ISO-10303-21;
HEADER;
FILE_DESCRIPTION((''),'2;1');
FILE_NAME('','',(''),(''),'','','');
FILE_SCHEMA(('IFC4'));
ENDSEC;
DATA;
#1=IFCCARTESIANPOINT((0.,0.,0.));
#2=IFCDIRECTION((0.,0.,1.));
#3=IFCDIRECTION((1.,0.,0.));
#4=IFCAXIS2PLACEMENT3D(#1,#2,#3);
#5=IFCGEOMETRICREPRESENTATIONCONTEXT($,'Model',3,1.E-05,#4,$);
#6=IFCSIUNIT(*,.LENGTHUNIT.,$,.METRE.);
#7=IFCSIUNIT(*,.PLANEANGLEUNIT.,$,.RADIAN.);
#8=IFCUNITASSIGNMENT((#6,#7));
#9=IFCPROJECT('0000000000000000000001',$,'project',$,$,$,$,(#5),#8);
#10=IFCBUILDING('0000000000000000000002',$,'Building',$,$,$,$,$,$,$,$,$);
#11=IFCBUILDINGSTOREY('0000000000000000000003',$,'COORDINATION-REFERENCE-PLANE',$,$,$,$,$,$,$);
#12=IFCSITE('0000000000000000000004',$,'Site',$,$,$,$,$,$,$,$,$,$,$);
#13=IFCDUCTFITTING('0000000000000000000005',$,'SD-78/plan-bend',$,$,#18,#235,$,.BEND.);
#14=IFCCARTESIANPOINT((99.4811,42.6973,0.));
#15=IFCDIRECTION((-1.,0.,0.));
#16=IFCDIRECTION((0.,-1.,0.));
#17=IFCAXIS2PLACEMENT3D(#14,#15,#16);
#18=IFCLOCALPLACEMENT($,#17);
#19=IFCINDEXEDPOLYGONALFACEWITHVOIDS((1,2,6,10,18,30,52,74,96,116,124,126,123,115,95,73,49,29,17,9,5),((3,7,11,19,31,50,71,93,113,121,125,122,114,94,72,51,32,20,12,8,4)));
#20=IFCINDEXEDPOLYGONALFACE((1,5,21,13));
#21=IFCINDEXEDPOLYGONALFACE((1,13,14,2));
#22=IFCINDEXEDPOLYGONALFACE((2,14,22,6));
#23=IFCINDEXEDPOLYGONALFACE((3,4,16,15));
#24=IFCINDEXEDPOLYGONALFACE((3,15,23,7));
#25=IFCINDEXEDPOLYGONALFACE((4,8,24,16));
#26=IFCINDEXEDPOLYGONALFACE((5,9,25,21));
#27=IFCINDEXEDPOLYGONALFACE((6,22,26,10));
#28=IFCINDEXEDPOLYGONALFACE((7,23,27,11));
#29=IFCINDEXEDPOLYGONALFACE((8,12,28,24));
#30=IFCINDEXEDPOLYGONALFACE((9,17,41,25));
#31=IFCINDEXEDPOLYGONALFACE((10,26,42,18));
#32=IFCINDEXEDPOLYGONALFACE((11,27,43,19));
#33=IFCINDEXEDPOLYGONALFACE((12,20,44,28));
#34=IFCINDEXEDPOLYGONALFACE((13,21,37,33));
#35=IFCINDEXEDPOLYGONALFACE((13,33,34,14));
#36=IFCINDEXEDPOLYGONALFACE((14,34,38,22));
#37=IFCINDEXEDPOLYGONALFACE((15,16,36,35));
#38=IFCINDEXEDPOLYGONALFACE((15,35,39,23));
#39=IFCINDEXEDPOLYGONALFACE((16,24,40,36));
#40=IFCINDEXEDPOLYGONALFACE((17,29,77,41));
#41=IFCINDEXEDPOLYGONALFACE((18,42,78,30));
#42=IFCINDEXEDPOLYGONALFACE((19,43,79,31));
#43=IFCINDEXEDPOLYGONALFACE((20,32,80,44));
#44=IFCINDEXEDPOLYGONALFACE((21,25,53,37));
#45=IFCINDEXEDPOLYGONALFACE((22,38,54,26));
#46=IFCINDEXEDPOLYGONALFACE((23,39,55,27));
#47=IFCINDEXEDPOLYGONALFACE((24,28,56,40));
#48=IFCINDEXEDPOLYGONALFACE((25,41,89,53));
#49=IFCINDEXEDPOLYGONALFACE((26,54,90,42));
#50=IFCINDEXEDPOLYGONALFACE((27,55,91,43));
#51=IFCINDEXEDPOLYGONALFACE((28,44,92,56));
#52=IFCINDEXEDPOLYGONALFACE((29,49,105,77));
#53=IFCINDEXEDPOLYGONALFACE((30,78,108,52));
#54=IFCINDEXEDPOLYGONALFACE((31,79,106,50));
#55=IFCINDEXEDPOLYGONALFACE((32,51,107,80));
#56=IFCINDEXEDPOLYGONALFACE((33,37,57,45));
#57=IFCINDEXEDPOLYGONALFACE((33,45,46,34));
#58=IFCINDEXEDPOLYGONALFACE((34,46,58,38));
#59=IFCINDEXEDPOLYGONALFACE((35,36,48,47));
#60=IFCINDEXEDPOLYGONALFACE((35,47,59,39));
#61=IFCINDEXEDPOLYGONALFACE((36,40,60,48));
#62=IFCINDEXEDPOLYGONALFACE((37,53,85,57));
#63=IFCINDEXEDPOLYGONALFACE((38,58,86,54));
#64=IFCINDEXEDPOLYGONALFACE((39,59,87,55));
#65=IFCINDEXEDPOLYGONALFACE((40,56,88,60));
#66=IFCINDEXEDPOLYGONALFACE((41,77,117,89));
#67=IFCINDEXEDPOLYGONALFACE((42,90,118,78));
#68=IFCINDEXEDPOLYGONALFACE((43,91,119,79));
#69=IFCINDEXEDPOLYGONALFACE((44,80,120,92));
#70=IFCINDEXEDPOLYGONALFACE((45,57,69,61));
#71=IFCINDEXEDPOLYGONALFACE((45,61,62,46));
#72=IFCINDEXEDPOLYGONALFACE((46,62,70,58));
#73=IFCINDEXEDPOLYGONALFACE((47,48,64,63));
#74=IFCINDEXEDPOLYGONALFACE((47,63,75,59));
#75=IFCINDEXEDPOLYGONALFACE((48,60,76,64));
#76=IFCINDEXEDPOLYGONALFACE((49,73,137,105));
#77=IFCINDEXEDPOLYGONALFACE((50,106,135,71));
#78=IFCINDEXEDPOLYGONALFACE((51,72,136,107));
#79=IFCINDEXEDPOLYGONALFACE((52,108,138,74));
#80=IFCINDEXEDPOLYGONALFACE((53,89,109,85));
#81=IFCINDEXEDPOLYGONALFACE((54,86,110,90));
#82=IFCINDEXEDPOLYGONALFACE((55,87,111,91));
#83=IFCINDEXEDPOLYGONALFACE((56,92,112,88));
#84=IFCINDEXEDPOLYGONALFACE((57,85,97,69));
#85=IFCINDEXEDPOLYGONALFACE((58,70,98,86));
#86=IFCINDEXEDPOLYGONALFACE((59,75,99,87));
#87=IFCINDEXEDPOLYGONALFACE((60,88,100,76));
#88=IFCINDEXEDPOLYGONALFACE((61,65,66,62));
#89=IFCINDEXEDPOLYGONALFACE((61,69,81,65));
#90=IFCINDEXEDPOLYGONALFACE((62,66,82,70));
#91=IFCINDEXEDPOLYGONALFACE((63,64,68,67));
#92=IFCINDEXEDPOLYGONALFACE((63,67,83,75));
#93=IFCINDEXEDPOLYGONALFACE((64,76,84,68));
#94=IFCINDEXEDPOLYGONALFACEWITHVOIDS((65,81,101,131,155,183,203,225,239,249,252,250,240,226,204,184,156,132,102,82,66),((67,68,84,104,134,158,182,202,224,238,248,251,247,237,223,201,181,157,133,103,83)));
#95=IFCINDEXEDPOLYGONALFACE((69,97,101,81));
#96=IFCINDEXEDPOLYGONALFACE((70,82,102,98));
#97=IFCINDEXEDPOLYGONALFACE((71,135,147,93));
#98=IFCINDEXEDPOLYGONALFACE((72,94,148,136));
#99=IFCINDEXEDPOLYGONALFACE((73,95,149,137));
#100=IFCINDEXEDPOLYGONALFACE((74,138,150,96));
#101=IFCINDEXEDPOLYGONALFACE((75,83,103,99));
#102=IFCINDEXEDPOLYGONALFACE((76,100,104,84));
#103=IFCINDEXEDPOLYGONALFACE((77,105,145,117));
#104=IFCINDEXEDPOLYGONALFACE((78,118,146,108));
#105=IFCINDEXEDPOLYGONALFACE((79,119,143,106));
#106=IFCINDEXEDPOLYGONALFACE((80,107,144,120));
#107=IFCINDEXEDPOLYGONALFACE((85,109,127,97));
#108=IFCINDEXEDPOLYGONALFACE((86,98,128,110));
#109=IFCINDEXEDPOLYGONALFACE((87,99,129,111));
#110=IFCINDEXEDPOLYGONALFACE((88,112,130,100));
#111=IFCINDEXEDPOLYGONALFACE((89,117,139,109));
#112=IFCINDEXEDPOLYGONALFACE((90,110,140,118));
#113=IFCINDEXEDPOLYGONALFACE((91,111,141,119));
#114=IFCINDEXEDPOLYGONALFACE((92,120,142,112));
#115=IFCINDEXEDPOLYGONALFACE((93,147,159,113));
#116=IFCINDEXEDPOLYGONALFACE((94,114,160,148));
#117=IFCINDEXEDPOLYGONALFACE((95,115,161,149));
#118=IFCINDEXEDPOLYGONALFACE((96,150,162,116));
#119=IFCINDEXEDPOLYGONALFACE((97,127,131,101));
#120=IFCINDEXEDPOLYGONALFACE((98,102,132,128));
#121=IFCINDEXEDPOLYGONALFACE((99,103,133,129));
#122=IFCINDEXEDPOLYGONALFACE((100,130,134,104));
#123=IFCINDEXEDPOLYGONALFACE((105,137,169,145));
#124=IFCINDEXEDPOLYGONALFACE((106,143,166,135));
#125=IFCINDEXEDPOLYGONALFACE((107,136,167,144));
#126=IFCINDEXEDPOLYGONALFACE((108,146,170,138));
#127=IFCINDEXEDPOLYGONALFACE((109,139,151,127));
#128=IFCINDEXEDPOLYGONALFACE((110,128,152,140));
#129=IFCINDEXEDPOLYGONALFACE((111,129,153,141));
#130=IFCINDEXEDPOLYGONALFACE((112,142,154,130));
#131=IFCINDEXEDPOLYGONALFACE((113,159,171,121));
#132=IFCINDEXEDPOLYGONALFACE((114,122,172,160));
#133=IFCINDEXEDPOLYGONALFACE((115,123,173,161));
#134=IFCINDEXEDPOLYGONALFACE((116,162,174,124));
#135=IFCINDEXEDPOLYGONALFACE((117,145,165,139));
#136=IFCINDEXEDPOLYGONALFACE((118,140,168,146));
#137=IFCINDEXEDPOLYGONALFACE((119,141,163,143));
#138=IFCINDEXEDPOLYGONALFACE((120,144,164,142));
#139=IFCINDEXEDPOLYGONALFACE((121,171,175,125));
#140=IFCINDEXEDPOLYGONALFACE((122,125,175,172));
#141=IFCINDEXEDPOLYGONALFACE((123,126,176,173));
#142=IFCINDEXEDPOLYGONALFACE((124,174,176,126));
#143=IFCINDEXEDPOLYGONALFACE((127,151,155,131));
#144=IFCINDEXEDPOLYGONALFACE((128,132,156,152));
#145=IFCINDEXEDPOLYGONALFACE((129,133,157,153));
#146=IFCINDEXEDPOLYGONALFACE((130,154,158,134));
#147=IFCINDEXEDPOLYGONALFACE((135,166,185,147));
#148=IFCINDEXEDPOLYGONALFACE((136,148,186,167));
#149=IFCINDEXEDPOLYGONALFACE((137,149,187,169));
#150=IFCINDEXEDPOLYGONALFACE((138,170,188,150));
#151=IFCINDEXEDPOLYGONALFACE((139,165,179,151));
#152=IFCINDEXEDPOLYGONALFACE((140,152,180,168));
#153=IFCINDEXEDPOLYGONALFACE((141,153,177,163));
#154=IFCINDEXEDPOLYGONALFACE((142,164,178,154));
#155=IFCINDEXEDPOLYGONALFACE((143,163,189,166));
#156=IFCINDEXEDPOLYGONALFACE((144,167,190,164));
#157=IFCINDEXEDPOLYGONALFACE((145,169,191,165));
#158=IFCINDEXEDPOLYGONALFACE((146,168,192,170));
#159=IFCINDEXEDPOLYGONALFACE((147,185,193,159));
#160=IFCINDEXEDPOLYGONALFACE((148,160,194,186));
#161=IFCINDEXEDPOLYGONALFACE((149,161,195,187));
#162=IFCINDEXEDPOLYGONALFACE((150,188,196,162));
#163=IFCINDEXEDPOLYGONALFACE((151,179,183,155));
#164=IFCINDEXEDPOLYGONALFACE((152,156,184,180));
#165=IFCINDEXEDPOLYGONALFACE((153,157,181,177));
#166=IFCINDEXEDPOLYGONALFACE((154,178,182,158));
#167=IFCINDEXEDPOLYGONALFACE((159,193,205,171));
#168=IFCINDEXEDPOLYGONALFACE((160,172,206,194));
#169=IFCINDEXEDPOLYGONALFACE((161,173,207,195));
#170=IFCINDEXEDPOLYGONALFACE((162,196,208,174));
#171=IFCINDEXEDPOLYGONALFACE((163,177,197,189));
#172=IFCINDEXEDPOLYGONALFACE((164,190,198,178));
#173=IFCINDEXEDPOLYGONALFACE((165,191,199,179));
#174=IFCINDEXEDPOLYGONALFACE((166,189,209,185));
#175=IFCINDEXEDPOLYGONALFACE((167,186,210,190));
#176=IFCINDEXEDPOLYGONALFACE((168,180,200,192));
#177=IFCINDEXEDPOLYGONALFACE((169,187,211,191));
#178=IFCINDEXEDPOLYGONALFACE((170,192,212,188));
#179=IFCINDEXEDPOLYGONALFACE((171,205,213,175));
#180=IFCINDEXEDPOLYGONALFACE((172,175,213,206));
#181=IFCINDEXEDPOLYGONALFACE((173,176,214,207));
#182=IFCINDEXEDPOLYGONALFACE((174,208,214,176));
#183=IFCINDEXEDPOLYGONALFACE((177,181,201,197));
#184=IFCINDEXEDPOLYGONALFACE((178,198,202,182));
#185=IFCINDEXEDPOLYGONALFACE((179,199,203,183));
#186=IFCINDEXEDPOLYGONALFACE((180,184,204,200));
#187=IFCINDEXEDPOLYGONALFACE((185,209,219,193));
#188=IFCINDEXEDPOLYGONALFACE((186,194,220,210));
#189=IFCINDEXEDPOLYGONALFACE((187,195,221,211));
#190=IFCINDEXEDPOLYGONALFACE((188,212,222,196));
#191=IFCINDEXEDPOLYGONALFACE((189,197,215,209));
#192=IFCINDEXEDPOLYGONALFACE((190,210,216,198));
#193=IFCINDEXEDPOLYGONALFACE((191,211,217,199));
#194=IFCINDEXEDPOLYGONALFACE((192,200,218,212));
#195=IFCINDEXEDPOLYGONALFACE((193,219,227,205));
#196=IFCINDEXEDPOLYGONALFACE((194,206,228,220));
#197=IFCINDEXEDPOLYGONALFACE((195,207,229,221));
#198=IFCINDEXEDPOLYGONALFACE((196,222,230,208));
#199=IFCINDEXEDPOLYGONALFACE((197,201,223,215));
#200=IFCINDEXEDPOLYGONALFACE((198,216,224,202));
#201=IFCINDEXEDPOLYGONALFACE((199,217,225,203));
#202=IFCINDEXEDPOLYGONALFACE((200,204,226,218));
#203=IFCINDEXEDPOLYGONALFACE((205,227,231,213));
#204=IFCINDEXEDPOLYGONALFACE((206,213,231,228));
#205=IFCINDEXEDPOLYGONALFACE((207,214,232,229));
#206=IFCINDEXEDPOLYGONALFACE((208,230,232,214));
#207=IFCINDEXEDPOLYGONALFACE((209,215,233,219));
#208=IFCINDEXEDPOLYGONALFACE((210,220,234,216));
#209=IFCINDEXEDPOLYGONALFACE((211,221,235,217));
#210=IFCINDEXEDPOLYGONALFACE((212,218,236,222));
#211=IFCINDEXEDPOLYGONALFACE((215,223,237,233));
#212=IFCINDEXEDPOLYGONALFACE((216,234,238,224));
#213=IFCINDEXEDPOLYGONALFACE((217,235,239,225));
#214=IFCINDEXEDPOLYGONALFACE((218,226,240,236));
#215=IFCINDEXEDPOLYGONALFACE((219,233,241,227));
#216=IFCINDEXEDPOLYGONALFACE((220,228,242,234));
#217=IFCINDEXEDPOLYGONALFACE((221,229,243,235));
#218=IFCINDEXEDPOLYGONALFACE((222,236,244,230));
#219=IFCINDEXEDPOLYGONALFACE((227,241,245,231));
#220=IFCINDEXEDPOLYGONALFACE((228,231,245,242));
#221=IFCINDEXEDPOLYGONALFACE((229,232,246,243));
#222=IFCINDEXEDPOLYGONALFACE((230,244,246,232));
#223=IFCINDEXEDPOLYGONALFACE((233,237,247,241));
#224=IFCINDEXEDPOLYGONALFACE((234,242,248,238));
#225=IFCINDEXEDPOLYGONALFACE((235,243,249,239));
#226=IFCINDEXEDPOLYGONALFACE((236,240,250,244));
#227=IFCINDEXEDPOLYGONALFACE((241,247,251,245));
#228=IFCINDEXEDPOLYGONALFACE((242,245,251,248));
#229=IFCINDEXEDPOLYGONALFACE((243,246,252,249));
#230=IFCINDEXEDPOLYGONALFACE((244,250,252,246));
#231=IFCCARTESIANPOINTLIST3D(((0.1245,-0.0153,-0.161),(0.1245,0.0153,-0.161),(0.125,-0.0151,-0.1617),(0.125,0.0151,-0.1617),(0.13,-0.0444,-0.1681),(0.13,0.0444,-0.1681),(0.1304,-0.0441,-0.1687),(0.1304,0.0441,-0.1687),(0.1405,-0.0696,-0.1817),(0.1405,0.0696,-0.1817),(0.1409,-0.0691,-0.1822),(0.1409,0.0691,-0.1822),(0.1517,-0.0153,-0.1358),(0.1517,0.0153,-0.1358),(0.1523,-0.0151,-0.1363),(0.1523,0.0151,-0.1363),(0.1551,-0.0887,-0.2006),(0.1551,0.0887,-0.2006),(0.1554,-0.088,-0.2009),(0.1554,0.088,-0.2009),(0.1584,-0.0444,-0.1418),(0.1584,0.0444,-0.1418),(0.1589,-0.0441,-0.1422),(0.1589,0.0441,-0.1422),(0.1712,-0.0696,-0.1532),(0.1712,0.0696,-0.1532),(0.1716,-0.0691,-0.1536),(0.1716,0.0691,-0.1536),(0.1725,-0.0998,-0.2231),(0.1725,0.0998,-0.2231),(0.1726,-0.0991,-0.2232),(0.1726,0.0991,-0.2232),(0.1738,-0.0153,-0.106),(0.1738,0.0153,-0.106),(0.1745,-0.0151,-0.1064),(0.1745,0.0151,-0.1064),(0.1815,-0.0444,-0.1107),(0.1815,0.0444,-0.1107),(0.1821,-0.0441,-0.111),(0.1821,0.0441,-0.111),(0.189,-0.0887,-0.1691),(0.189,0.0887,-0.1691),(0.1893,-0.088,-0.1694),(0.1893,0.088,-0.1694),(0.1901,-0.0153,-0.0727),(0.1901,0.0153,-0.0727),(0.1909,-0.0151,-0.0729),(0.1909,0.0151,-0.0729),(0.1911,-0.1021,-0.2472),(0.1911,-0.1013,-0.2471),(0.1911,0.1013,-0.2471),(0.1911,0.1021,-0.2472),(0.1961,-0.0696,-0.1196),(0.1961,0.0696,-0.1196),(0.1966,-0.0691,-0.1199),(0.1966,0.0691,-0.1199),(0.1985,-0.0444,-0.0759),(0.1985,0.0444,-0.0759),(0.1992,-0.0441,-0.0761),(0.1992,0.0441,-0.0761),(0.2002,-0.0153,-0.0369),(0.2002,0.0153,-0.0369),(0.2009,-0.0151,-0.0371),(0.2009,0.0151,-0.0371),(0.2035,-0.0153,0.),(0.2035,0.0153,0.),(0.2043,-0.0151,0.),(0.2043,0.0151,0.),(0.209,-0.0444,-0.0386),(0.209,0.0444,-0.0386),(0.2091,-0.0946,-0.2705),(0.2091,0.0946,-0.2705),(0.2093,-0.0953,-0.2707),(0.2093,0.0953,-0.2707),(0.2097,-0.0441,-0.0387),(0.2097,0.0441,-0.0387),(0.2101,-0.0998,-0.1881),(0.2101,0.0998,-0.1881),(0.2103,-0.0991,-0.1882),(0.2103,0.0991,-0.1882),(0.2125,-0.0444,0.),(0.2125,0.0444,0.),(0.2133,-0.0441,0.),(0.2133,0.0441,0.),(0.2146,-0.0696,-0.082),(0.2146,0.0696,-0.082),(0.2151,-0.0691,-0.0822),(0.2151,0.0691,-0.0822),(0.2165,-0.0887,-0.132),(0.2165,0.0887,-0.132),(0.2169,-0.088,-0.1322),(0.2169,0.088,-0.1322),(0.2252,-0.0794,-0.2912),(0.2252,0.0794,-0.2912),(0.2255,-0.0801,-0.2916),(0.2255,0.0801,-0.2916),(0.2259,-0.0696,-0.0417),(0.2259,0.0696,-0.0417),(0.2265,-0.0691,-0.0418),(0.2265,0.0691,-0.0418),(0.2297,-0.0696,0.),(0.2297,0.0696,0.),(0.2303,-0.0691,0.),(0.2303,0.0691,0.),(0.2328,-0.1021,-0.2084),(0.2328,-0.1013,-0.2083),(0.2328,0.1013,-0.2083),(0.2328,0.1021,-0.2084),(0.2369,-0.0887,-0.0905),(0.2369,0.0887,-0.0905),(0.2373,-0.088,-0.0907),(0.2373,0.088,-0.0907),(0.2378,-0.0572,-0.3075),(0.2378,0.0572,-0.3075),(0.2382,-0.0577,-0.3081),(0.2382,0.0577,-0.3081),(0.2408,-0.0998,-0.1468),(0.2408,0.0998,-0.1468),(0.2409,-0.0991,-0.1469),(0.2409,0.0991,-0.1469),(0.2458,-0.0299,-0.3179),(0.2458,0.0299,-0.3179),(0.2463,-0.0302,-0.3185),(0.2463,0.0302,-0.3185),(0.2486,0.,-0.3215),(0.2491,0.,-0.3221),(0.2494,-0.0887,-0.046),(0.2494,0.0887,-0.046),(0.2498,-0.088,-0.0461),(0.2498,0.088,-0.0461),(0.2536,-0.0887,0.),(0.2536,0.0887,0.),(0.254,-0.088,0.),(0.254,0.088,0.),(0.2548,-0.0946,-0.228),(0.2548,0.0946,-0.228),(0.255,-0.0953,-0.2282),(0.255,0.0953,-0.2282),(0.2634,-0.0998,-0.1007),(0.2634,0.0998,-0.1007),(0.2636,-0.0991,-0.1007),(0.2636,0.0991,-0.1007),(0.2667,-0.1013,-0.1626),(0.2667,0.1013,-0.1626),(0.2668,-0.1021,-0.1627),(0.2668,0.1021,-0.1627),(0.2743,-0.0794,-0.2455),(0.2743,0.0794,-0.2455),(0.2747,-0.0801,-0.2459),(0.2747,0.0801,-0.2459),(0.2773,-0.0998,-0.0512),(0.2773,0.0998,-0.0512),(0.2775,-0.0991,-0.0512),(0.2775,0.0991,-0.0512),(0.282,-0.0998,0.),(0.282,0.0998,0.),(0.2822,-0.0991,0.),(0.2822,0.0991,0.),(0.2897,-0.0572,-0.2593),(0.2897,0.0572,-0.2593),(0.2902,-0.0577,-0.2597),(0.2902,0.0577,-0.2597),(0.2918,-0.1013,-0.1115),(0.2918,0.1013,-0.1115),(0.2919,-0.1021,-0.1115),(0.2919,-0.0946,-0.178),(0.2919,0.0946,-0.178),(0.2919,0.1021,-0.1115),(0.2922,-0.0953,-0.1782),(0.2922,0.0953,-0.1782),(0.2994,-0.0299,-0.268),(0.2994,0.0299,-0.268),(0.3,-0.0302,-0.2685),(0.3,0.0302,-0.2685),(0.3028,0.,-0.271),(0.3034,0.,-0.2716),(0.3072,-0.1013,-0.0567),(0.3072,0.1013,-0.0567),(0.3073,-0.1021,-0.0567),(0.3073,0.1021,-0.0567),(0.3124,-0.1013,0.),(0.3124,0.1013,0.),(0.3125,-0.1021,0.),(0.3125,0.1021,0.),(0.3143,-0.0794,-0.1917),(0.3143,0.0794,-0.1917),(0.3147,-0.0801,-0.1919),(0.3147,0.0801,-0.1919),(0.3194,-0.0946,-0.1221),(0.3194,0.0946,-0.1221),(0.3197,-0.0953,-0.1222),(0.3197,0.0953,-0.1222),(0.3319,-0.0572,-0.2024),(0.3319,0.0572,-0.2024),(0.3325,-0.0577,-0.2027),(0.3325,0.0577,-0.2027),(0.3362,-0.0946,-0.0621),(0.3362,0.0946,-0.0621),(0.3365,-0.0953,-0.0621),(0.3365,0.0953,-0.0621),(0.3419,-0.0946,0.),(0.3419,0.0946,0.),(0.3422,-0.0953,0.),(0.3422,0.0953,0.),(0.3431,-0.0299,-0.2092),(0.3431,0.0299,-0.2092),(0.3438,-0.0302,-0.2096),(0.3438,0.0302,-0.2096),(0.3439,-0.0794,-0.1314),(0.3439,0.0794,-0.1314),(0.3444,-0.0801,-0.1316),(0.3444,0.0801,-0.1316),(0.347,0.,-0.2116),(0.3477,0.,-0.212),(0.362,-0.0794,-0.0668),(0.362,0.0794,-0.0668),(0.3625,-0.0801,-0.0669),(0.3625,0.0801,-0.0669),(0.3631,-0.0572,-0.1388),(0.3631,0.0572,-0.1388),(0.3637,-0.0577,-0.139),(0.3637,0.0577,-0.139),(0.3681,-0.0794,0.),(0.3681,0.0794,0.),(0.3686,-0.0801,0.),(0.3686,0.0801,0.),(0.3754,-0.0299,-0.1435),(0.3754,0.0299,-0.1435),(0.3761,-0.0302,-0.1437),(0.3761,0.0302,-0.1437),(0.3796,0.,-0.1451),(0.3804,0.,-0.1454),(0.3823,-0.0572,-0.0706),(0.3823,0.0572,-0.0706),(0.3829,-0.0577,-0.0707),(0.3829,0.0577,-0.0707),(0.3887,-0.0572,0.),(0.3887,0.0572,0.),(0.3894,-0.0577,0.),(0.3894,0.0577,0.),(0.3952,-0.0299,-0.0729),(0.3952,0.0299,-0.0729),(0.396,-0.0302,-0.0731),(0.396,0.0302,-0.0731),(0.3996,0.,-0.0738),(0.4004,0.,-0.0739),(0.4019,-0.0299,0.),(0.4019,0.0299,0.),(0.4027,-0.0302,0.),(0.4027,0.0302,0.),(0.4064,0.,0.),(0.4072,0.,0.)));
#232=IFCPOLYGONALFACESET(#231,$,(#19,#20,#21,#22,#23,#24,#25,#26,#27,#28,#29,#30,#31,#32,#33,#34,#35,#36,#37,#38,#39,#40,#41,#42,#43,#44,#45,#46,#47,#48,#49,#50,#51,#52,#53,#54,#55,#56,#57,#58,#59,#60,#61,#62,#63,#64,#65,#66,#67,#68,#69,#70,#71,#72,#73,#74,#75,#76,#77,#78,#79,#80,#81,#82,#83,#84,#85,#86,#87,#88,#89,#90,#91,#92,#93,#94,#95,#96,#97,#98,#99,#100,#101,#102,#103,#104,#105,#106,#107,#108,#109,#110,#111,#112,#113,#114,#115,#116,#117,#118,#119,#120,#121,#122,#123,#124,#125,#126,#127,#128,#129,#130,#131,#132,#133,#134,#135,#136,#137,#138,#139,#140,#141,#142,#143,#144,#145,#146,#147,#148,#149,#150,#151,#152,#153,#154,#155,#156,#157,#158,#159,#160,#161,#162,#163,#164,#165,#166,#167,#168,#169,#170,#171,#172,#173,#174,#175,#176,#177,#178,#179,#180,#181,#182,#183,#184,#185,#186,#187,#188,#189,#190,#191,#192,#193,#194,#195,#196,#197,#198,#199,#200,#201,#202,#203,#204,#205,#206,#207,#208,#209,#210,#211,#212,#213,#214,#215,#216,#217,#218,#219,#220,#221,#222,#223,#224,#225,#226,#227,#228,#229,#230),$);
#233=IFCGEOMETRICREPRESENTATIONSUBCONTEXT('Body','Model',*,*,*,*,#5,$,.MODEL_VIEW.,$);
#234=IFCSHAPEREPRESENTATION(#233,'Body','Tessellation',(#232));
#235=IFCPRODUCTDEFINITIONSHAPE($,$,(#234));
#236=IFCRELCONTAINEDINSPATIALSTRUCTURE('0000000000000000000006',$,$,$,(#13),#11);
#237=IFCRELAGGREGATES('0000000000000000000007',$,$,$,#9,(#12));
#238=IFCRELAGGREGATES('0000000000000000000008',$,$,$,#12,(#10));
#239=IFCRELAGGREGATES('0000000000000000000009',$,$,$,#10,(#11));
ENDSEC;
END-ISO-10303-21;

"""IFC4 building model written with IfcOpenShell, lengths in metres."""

from ifc_helpers import new_model, entity, si_unit, frame, origin_with_axes, place, context, subcontext, project, spatial, element, save


model = new_model("IFC4")

# Units and contexts
model_context_1 = context("Model", 3, precision=1e-05, world=origin_with_axes())
body_context_1 = subcontext(model_context_1, "Body", "Model", "MODEL_VIEW")
ifc_project = project(units=[si_unit("LENGTHUNIT", "METRE"), si_unit("PLANEANGLEUNIT", "RADIAN")], contexts=[model_context_1])

# Site, building, storey
site = spatial("IfcSite", under=ifc_project, Name="Site")
building = spatial("IfcBuilding", under=site, Name="Building")
storey = spatial("IfcBuildingStorey", under=building, Name="COORDINATION-REFERENCE-PLANE")

# Duct fitting
duct_fitting_1_placement = place(None, frame((99.4811, 42.6973, 0.0), z_axis=(-1.0, 0.0, 0.0), x_axis=(0.0, -1.0, 0.0)))
element("IfcDuctFitting", 1, at=duct_fitting_1_placement, inside=storey, Name="SD-78/plan-bend", PredefinedType="BEND", context=body_context_1, shape_type="SweptSolid", body=[
    entity("IfcRevolvedAreaSolid", entity("IfcCircleHollowProfileDef", "AREA", None, entity("IfcAxis2Placement2D", entity("IfcCartesianPoint", [0.3048, 0.0])), 0.1024, 0.0008), entity("IfcAxis2Placement3D", entity("IfcCartesianPoint", [0.0, 0.0, 0.0]), entity("IfcDirection", [0.0, 0.0, 1.0]), entity("IfcDirection", [1.0, 0.0, 0.0])), entity("IfcAxis1Placement", entity("IfcCartesianPoint", [0.0, 0.0, 0.0]), entity("IfcDirection", [0.0, 1.0, 0.0])), 0.912619),
])

save(model, "model.ifc")
